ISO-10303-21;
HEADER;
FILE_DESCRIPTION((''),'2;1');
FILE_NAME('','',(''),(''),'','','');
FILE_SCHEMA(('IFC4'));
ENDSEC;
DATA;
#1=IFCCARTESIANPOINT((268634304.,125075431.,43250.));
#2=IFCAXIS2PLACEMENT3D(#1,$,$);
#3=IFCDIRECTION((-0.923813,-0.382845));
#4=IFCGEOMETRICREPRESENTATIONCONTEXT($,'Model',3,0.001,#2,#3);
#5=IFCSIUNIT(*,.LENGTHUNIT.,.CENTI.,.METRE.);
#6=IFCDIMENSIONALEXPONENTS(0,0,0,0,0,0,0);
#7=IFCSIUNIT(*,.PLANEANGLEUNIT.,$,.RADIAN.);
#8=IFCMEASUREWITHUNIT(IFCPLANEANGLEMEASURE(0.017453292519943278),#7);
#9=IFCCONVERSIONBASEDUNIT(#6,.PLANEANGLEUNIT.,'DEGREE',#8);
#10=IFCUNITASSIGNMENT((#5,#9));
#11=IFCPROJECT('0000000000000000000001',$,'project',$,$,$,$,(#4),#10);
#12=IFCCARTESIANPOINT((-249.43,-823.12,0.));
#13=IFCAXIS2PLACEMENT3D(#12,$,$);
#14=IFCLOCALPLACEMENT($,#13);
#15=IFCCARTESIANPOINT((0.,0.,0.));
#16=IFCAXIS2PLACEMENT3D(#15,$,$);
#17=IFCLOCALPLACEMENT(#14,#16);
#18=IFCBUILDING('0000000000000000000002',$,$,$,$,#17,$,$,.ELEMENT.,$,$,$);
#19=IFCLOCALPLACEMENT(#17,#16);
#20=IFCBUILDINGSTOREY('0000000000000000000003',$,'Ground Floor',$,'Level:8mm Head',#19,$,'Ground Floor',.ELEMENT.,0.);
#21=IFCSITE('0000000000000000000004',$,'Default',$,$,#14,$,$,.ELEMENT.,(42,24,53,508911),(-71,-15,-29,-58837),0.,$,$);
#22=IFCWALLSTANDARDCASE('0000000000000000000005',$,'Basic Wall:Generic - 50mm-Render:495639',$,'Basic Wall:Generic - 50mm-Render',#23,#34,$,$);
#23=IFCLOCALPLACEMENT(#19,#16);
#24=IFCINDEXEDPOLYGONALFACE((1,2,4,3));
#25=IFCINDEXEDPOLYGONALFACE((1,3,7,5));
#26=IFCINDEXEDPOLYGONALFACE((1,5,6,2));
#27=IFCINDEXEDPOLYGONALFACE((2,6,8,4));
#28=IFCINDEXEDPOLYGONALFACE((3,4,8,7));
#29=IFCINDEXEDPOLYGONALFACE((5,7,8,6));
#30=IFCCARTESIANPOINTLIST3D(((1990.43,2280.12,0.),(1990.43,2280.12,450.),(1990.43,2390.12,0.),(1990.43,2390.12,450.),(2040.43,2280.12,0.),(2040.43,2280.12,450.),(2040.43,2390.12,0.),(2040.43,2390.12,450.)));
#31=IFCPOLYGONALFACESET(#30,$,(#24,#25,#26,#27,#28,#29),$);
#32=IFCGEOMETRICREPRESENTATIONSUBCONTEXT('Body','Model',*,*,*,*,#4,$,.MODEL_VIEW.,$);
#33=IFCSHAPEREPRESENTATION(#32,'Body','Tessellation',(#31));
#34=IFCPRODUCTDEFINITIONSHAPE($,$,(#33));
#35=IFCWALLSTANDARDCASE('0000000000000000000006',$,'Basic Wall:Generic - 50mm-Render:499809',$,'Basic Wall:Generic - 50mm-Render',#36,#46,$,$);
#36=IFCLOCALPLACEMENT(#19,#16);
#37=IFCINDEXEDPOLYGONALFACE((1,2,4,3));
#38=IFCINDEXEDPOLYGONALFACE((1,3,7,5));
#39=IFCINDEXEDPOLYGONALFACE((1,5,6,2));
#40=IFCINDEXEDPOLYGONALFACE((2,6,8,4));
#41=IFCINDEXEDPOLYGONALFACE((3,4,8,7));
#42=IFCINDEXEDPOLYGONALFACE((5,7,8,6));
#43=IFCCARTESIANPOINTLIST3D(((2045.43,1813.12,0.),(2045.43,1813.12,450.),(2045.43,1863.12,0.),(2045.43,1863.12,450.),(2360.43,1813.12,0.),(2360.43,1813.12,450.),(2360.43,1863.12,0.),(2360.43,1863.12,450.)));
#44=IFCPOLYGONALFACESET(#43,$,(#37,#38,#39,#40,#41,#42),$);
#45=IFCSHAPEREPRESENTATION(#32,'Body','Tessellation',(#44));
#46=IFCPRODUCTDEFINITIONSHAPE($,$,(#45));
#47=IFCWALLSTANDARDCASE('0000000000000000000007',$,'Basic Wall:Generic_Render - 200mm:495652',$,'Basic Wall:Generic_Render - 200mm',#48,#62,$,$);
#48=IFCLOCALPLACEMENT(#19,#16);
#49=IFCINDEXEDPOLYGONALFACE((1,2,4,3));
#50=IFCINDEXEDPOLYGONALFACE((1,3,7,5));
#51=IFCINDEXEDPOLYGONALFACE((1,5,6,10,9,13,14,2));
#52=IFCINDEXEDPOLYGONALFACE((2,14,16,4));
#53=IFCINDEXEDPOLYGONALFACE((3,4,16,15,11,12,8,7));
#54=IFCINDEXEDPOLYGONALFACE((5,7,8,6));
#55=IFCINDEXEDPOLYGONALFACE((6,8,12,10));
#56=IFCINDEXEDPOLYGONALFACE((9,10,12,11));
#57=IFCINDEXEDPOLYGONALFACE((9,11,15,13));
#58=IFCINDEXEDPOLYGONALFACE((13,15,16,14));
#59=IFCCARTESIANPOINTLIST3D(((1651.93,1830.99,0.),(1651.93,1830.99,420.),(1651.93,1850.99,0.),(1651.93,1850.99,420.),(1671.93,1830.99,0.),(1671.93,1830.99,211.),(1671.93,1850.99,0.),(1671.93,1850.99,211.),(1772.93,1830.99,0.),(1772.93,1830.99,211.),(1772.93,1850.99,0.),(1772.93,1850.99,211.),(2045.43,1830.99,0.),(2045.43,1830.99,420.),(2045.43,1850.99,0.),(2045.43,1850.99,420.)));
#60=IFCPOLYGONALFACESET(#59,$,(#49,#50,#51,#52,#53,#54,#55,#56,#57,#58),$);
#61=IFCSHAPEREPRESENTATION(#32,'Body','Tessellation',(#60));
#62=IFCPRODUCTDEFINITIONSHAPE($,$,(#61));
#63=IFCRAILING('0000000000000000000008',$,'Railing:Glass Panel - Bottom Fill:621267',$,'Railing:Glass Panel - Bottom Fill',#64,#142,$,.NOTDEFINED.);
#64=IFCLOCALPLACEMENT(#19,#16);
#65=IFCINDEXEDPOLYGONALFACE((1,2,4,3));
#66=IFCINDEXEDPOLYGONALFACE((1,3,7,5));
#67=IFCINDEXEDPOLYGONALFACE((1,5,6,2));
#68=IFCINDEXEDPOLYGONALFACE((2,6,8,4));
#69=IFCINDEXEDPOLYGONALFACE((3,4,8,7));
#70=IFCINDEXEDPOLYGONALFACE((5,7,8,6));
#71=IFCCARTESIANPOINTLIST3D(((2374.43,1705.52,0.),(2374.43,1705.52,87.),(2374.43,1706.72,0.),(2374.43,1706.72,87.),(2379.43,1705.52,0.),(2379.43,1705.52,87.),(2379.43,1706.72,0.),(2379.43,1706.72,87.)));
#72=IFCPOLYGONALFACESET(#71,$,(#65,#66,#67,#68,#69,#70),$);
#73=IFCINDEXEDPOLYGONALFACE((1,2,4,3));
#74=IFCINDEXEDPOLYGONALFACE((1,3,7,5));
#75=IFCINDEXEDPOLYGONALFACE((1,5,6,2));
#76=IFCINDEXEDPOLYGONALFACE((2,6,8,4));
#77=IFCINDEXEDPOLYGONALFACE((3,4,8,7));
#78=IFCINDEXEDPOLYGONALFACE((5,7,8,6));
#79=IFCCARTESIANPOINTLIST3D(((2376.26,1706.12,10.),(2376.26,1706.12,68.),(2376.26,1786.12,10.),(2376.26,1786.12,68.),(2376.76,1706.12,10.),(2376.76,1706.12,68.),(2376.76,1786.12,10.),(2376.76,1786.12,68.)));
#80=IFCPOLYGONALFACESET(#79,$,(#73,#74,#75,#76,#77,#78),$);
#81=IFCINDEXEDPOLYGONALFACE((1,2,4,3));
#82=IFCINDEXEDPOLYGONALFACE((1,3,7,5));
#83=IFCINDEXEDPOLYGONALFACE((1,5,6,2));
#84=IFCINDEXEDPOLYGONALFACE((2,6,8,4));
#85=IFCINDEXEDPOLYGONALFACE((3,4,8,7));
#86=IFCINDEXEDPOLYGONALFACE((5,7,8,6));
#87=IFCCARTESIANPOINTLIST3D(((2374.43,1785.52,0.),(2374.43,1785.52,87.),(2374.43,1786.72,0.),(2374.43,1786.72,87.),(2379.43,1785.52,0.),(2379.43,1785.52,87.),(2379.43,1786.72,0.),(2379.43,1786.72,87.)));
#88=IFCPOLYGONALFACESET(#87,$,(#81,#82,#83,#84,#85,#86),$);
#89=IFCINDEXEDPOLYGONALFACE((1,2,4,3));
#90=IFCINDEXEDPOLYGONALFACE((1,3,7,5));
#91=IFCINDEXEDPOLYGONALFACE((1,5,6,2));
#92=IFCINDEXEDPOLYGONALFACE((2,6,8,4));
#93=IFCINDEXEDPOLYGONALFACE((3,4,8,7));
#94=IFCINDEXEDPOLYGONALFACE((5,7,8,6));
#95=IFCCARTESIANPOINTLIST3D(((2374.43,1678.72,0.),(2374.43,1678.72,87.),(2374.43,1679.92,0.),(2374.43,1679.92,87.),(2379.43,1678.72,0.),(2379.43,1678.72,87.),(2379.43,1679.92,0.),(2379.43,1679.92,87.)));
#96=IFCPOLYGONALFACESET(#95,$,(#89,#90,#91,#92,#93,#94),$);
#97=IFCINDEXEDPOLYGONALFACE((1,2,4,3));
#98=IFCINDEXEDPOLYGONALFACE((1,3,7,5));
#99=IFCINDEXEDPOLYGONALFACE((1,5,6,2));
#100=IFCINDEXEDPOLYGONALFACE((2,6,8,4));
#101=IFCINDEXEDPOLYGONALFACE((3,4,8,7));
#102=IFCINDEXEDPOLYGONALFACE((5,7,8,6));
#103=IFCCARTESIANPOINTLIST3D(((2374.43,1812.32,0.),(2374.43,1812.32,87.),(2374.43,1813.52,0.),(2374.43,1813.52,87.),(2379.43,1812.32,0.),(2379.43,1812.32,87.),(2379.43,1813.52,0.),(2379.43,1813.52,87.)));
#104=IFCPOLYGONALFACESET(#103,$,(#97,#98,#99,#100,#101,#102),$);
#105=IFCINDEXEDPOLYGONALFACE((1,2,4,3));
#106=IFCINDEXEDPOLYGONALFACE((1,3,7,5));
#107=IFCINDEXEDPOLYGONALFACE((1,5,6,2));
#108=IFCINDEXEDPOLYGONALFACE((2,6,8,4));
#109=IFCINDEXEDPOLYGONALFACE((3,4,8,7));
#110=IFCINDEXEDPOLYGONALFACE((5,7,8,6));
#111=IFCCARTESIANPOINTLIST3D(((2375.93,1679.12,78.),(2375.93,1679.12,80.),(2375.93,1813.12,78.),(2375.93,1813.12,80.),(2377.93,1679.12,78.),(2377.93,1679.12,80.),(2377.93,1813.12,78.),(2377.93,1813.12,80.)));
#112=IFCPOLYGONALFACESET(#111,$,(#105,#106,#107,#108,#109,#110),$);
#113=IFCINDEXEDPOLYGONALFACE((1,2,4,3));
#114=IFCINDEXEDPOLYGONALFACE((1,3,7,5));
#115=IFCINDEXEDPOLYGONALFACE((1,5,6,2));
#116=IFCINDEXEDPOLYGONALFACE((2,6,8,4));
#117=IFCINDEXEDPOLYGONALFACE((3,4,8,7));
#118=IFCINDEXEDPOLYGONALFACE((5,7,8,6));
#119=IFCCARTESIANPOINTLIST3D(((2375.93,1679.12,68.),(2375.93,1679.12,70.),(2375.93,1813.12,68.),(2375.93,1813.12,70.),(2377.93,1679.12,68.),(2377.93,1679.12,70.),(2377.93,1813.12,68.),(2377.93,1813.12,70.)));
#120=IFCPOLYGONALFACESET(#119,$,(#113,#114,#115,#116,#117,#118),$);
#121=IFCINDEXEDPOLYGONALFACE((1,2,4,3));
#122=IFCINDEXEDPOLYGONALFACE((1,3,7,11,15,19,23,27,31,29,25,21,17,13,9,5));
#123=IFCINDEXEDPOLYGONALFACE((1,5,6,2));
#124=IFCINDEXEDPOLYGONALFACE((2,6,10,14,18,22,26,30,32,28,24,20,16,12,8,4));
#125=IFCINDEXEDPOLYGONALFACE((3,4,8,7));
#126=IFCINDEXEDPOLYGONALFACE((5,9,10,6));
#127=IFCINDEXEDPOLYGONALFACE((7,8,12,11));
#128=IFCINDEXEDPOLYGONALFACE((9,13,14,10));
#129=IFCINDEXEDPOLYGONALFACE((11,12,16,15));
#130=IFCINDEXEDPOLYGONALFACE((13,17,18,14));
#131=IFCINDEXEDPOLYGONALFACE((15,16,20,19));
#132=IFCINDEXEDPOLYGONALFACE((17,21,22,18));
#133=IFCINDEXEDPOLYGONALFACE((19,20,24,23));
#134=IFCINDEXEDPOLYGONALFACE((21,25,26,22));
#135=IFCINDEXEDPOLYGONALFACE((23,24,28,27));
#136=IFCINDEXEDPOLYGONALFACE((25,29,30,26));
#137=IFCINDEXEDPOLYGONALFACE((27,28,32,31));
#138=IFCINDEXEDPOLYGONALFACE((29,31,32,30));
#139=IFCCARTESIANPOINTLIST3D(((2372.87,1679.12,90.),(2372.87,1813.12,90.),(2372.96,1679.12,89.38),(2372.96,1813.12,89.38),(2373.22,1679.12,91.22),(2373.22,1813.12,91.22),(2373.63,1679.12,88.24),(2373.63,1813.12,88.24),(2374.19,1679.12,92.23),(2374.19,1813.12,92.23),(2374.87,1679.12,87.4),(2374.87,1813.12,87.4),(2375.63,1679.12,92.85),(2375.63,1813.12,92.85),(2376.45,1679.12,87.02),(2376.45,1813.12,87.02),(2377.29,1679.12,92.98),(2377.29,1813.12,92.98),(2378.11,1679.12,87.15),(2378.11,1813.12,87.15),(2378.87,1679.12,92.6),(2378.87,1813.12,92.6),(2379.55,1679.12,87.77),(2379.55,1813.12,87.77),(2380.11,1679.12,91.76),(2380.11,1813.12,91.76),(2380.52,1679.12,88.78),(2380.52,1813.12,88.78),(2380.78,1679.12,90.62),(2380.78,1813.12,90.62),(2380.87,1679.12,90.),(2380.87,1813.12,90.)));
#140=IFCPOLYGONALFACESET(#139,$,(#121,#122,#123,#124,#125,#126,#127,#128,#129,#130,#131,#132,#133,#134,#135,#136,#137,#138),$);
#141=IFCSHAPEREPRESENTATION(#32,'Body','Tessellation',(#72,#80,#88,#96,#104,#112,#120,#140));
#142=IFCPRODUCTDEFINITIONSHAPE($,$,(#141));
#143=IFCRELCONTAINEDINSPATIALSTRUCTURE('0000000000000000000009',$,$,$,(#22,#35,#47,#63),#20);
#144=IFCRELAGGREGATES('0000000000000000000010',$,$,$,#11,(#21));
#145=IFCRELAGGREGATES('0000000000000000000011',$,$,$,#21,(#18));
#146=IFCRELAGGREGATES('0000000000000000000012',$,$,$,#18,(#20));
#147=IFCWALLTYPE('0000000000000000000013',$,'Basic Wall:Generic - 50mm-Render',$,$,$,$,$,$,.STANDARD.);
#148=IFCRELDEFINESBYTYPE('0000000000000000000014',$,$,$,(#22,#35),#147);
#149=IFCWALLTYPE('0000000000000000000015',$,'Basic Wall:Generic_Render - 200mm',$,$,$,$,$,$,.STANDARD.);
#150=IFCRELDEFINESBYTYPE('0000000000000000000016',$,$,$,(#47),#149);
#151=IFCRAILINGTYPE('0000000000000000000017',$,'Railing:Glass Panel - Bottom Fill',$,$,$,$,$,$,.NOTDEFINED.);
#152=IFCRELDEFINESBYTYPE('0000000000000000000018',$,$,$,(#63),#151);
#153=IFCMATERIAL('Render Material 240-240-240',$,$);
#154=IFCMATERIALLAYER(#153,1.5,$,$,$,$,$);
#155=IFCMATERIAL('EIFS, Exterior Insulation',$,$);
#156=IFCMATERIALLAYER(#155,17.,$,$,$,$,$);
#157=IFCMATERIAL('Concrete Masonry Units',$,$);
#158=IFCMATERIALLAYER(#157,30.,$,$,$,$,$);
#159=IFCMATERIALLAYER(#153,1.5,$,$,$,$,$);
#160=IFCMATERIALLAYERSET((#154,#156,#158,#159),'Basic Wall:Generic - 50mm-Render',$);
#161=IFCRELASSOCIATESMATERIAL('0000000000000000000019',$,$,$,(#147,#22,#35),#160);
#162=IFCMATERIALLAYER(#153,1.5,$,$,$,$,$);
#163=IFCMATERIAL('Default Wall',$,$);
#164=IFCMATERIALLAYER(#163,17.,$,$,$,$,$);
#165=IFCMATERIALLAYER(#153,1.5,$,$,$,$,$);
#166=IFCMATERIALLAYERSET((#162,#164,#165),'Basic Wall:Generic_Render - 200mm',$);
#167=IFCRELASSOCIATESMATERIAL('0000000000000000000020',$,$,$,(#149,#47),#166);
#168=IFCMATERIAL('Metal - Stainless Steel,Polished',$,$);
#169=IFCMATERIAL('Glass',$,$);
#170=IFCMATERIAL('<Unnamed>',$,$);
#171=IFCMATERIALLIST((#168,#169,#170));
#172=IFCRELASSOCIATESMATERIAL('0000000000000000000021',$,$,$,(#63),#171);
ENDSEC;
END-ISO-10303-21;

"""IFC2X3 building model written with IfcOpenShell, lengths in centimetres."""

from ifc_helpers import new_model, entity, si_unit, converted_unit, direction, frame, frame_2d, origin, place, context, subcontext, project, spatial, polyline, rectangle, outline, extrude, material, material_list, layer, layer_set, layer_usage, type_object, element, save


model = new_model("IFC2X3")

# Units and contexts
model_context = context("Model", 3, precision=0.001, world=frame((268634304.0, 125075431.0, 43250.0)), true_north=direction((-0.923813, -0.382845)))
body_context = subcontext(model_context, "Body", "Model", "MODEL_VIEW")
ifc_project = project(units=[si_unit("LENGTHUNIT", "METRE", prefix="CENTI"), converted_unit("PLANEANGLEUNIT", "DEGREE", entity("IfcPlaneAngleMeasure", 0.017453292519943278), si_unit("PLANEANGLEUNIT", "RADIAN"), dimensions=[0, 0, 0, 0, 0, 0, 0])], contexts=[model_context])

# Site, building, storey
site_placement = place(None, frame((-249.43, -823.12, 0.0)))
site = spatial("IfcSite", under=ifc_project, at=site_placement, Name="Default", CompositionType="ELEMENT", RefLatitude=(42, 24, 53, 508911), RefLongitude=(-71, -15, -29, -58837), RefElevation=0.0)
building_placement = place(site_placement, origin())
building = spatial("IfcBuilding", under=site, at=building_placement, CompositionType="ELEMENT")
storey_placement = place(building_placement, origin())
storey = spatial("IfcBuildingStorey", under=building, at=storey_placement, Name="Ground Floor", ObjectType="Level:8mm Head", LongName="Ground Floor", CompositionType="ELEMENT", Elevation=0.0)

# Shared definitions
ifc_material_1 = material(Name="Glass")

# Walls
ifc_material_2 = material(Name="Render Material 240-240-240")
ifc_layer_1 = layer(ifc_material_2, 1.5)
ifc_material_3 = material(Name="EIFS, Exterior Insulation")
ifc_layer_2 = layer(ifc_material_3, 17.0)
ifc_material_4 = material(Name="Concrete Masonry Units")
ifc_layer_3 = layer(ifc_material_4, 30.0)
ifc_layer_4 = layer(ifc_material_2, 1.5)
ifc_layer_set_1 = layer_set([ifc_layer_1, ifc_layer_2, ifc_layer_3, ifc_layer_4], Name="Basic Wall:Generic - 50mm-Render")
ifc_layer_usage_1 = layer_usage(ifc_layer_set_1, "AXIS2", "POSITIVE", -25.0)
wall_type_1 = type_object("IfcWallType", Name="Basic Wall:Generic - 50mm-Render", PredefinedType="STANDARD", material=ifc_layer_set_1)
wall_1_placement = place(storey_placement, frame((2015.43, 2280.12, 0.0), z_axis=(0.0, 0.0, 1.0), x_axis=(0.0, 1.0, 0.0)))
element("IfcWallStandardCase", 1, at=wall_1_placement, inside=storey, type_object=wall_type_1, material=ifc_layer_usage_1, Name="Basic Wall:Generic - 50mm-Render:495639", ObjectType="Basic Wall:Generic - 50mm-Render", context=body_context, shape_type="SweptSolid", body=[
    extrude(rectangle(XDim=110.0, YDim=50.0, at=frame_2d((55.0, 0.0), x_axis=(-1.0, 0.0))), origin(), (0.0, 0.0, 1.0), 450.0),
])
ifc_layer_usage_2 = layer_usage(ifc_layer_set_1, "AXIS2", "NEGATIVE", 25.0)
wall_2_placement = place(storey_placement, frame((2360.43, 1838.12, 0.0), z_axis=(0.0, 0.0, 1.0), x_axis=(-1.0, 0.0, 0.0)))
element("IfcWallStandardCase", 2, at=wall_2_placement, inside=storey, type_object=wall_type_1, material=ifc_layer_usage_2, Name="Basic Wall:Generic - 50mm-Render:499809", ObjectType="Basic Wall:Generic - 50mm-Render", context=body_context, shape_type="SweptSolid", body=[
    extrude(rectangle(XDim=315.0, YDim=50.0, at=frame_2d((157.5, 0.0), x_axis=(-1.0, 0.0))), origin(), (0.0, 0.0, 1.0), 450.0),
])

# Wall, opening
ifc_layer_5 = layer(ifc_material_2, 1.5)
ifc_material_5 = material(Name="Default Wall")
ifc_layer_6 = layer(ifc_material_5, 17.0)
ifc_layer_7 = layer(ifc_material_2, 1.5)
ifc_layer_set_2 = layer_set([ifc_layer_5, ifc_layer_6, ifc_layer_7], Name="Basic Wall:Generic_Render - 200mm")
ifc_layer_usage_3 = layer_usage(ifc_layer_set_2, "AXIS2", "NEGATIVE", 10.0)
wall_type_2 = type_object("IfcWallType", Name="Basic Wall:Generic_Render - 200mm", PredefinedType="STANDARD", material=ifc_layer_set_2)
wall_3_placement = place(storey_placement, frame((1651.93, 1840.99, 0.0)))
wall_3 = element("IfcWallStandardCase", 3, at=wall_3_placement, inside=storey, type_object=wall_type_2, material=ifc_layer_usage_3, Name="Basic Wall:Generic_Render - 200mm:495652", ObjectType="Basic Wall:Generic_Render - 200mm", context=body_context, shape_type="SweptSolid", body=[
    extrude(rectangle(XDim=393.5, YDim=20.0, at=frame_2d((196.75, 0.0), x_axis=(1.0, 0.0))), origin(), (0.0, 0.0, 1.0), 420.0),
])
opening_placement = place(wall_3_placement, frame((20.0, -10.0, 0.0)))
element("IfcOpeningElement", 4, at=opening_placement, cuts=wall_3, ObjectType="Opening", context=body_context, shape_type="SweptSolid", body=[
    extrude(rectangle(XDim=211.0, YDim=101.0, at=frame_2d((105.5, 50.5), x_axis=(1.0, 0.0))), frame((0.0, 0.0, 0.0), z_axis=(0.0, 1.0, 0.0), x_axis=(0.0, 0.0, 1.0)), (0.0, 0.0, 1.0), 20.0),
])

# Railing
ifc_material_6 = material(Name="Metal - Stainless Steel,Polished")
ifc_material_7 = material(Name="<Unnamed>")
ifc_material_list = material_list([ifc_material_6, ifc_material_1, ifc_material_7])
railing_type = type_object("IfcRailingType", Name="Railing:Glass Panel - Bottom Fill", PredefinedType="NOTDEFINED")
railing_placement = place(storey_placement, frame((2372.71, 1678.72, 0.0)))
element("IfcRailing", 5, at=railing_placement, inside=storey, type_object=railing_type, material=ifc_material_list, Name="Railing:Glass Panel - Bottom Fill:621267", ObjectType="Railing:Glass Panel - Bottom Fill", PredefinedType="NOTDEFINED", context=body_context, shape_type="SweptSolid", body=[
    extrude(rectangle(XDim=5.0, YDim=1.2, at=frame_2d((0.0, 0.0), x_axis=(1.0, 0.0))), frame((4.22, 27.4, 0.0), z_axis=(0.0, 0.0, 1.0), x_axis=(-1.0, 0.0, 0.0)), (0.0, 0.0, 1.0), 87.0),
    extrude(rectangle(XDim=0.5, YDim=80.0, at=frame_2d((0.0, 0.0), x_axis=(1.0, 0.0))), frame((3.8, 67.4, 10.0), z_axis=(0.0, 0.0, 1.0), x_axis=(-1.0, 0.0, 0.0)), (0.0, 0.0, 1.0), 58.0),
    extrude(rectangle(XDim=5.0, YDim=1.2, at=frame_2d((0.0, 0.0), x_axis=(1.0, 0.0))), frame((4.22, 107.4, 0.0), z_axis=(0.0, 0.0, 1.0), x_axis=(-1.0, 0.0, 0.0)), (0.0, 0.0, 1.0), 87.0),
    extrude(rectangle(XDim=5.0, YDim=1.2, at=frame_2d((0.0, 0.0), x_axis=(1.0, 0.0))), frame((4.22, 0.6, 0.0), z_axis=(0.0, 0.0, 1.0), x_axis=(-1.0, 0.0, 0.0)), (0.0, 0.0, 1.0), 87.0),
    extrude(rectangle(XDim=5.0, YDim=1.2, at=frame_2d((0.0, 0.0), x_axis=(1.0, 0.0))), frame((4.22, 134.2, 0.0), z_axis=(0.0, 0.0, 1.0), x_axis=(-1.0, 0.0, 0.0)), (0.0, 0.0, 1.0), 87.0),
    extrude(rectangle(XDim=134.0, YDim=2.0, at=frame_2d((0.0, 0.0), x_axis=(1.0, 0.0))), frame((4.22, 67.4, 78.0), z_axis=(0.0, 0.0, 1.0), x_axis=(0.0, -1.0, 0.0)), (0.0, 0.0, 1.0), 2.0),
    extrude(rectangle(XDim=134.0, YDim=2.0, at=frame_2d((0.0, 0.0), x_axis=(1.0, 0.0))), frame((4.22, 67.4, 68.0), z_axis=(0.0, 0.0, 1.0), x_axis=(0.0, -1.0, 0.0)), (0.0, 0.0, 1.0), 2.0),
    extrude(outline(polyline([(-1.09, -3.85), (0.18, -3.85), (1.42, -3.18), (2.41, -1.97), (2.98, -0.41), (3.04, 1.22), (2.58, 2.63), (1.67, 3.59), (1.09, 3.85), (-0.18, 3.85), (-1.42, 3.18), (-2.41, 1.97), (-2.98, 0.41), (-3.04, -1.22), (-2.58, -2.63), (-1.67, -3.59), (-1.09, -3.85)])), frame((4.16, 0.4, 90.0), z_axis=(0.0, 1.0, 0.0), x_axis=(-0.27267, 0.0, -0.962108)), (0.0, 0.0, 1.0), 134.0),
])

save(model, "model.ifc")
